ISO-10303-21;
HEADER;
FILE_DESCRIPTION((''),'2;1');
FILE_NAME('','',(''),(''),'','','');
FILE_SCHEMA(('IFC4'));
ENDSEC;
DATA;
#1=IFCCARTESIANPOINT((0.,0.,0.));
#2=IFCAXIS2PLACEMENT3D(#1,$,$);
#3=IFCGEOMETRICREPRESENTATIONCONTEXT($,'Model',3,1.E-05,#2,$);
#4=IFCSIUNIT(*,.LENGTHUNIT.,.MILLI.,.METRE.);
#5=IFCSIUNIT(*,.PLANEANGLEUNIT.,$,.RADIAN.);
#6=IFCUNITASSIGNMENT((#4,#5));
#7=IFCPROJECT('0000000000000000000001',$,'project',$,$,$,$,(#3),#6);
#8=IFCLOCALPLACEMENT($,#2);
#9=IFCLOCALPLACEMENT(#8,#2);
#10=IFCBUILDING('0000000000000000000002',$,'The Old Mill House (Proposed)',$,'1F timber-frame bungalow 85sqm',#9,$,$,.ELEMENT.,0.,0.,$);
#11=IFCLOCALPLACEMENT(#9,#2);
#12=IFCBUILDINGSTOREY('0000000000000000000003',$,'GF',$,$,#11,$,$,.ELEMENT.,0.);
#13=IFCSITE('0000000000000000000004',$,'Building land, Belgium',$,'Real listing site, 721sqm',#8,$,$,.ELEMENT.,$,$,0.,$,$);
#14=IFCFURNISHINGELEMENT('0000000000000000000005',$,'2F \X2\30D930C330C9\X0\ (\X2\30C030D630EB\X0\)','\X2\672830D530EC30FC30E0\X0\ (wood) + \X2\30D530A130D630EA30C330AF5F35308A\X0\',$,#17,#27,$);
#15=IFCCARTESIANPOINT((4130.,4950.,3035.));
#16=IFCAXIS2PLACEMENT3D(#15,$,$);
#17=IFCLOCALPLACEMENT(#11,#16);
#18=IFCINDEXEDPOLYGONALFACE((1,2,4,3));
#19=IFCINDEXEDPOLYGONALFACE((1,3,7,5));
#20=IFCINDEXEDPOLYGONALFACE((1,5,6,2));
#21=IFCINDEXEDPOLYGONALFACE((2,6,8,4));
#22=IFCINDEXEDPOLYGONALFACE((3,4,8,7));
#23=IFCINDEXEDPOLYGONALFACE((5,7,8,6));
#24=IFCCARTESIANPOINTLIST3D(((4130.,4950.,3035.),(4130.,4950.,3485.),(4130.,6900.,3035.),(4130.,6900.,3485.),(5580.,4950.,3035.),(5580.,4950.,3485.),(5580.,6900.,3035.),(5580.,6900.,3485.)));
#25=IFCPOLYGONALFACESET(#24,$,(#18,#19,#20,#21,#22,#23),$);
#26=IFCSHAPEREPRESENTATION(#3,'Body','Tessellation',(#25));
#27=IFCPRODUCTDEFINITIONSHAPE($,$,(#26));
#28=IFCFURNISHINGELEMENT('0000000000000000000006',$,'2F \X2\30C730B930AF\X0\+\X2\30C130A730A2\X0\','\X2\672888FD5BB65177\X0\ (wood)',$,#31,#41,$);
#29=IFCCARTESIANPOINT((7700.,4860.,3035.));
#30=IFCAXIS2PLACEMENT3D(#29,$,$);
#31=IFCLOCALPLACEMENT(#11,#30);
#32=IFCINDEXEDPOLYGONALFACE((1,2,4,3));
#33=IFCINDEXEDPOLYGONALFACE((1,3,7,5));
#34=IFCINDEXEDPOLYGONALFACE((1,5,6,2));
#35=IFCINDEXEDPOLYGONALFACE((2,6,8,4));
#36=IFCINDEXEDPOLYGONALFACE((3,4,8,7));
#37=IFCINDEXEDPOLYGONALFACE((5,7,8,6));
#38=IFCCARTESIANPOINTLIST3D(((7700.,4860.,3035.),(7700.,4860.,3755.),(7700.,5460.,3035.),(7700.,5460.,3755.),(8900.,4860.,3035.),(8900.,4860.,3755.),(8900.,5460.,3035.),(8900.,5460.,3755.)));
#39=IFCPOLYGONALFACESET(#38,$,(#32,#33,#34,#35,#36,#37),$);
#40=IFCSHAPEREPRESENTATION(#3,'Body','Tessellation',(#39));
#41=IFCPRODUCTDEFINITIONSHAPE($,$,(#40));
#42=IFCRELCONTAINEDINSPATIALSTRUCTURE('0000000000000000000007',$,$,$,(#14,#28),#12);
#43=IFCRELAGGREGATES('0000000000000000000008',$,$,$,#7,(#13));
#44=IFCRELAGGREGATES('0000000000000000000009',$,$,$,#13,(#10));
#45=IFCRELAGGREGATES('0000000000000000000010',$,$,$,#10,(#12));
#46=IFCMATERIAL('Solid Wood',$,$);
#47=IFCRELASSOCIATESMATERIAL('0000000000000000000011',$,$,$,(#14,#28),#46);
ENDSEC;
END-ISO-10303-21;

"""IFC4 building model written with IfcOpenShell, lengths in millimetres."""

from ifc_helpers import new_model, si_unit, frame, frame_2d, origin, place, context, project, spatial, rectangle, extrude, material, element, save


model = new_model("IFC4")

# Units and contexts
model_context = context("Model", 3, precision=1e-05, world=origin())
ifc_project = project(units=[si_unit("LENGTHUNIT", "METRE", prefix="MILLI"), si_unit("PLANEANGLEUNIT", "RADIAN")], contexts=[model_context])

# Site, building, storey
site_placement = place(None, origin())
site = spatial("IfcSite", under=ifc_project, at=site_placement, Name="Building land, Belgium", ObjectType="Real listing site, 721sqm", CompositionType="ELEMENT", RefElevation=0.0)
building_placement = place(site_placement, origin())
building = spatial("IfcBuilding", under=site, at=building_placement, Name="The Old Mill House (Proposed)", ObjectType="1F timber-frame bungalow 85sqm", CompositionType="ELEMENT", ElevationOfRefHeight=0.0, ElevationOfTerrain=0.0)
storey_placement = place(building_placement, origin())
storey = spatial("IfcBuildingStorey", under=building, at=storey_placement, Name="GF", CompositionType="ELEMENT", Elevation=0.0)

# Shared definitions
ifc_material_1 = material(Name="Solid Wood")

# Furnishing elements
furnishing_1_placement = place(storey_placement, frame((4130.0, 4950.0, 3035.0)))
element("IfcFurnishingElement", 1, at=furnishing_1_placement, inside=storey, material=ifc_material_1, Name="2F ベッド (ダブル)", Description="木フレーム (wood) + ファブリック張り", context=model_context, shape_type="SweptSolid", body=[
    extrude(rectangle(XDim=1450.0, YDim=1950.0, at=frame_2d((725.0, 975.0))), frame((4130.0, 4950.0, 3035.0)), (0.0, 0.0, 1.0), 450.0),
])
furnishing_2_placement = place(storey_placement, frame((7700.0, 4860.0, 3035.0)))
element("IfcFurnishingElement", 2, at=furnishing_2_placement, inside=storey, material=ifc_material_1, Name="2F デスク+チェア", Description="木製家具 (wood)", context=model_context, shape_type="SweptSolid", body=[
    extrude(rectangle(XDim=1200.0, YDim=600.0, at=frame_2d((600.0, 300.0))), frame((7700.0, 4860.0, 3035.0)), (0.0, 0.0, 1.0), 720.0),
])

save(model, "model.ifc")
